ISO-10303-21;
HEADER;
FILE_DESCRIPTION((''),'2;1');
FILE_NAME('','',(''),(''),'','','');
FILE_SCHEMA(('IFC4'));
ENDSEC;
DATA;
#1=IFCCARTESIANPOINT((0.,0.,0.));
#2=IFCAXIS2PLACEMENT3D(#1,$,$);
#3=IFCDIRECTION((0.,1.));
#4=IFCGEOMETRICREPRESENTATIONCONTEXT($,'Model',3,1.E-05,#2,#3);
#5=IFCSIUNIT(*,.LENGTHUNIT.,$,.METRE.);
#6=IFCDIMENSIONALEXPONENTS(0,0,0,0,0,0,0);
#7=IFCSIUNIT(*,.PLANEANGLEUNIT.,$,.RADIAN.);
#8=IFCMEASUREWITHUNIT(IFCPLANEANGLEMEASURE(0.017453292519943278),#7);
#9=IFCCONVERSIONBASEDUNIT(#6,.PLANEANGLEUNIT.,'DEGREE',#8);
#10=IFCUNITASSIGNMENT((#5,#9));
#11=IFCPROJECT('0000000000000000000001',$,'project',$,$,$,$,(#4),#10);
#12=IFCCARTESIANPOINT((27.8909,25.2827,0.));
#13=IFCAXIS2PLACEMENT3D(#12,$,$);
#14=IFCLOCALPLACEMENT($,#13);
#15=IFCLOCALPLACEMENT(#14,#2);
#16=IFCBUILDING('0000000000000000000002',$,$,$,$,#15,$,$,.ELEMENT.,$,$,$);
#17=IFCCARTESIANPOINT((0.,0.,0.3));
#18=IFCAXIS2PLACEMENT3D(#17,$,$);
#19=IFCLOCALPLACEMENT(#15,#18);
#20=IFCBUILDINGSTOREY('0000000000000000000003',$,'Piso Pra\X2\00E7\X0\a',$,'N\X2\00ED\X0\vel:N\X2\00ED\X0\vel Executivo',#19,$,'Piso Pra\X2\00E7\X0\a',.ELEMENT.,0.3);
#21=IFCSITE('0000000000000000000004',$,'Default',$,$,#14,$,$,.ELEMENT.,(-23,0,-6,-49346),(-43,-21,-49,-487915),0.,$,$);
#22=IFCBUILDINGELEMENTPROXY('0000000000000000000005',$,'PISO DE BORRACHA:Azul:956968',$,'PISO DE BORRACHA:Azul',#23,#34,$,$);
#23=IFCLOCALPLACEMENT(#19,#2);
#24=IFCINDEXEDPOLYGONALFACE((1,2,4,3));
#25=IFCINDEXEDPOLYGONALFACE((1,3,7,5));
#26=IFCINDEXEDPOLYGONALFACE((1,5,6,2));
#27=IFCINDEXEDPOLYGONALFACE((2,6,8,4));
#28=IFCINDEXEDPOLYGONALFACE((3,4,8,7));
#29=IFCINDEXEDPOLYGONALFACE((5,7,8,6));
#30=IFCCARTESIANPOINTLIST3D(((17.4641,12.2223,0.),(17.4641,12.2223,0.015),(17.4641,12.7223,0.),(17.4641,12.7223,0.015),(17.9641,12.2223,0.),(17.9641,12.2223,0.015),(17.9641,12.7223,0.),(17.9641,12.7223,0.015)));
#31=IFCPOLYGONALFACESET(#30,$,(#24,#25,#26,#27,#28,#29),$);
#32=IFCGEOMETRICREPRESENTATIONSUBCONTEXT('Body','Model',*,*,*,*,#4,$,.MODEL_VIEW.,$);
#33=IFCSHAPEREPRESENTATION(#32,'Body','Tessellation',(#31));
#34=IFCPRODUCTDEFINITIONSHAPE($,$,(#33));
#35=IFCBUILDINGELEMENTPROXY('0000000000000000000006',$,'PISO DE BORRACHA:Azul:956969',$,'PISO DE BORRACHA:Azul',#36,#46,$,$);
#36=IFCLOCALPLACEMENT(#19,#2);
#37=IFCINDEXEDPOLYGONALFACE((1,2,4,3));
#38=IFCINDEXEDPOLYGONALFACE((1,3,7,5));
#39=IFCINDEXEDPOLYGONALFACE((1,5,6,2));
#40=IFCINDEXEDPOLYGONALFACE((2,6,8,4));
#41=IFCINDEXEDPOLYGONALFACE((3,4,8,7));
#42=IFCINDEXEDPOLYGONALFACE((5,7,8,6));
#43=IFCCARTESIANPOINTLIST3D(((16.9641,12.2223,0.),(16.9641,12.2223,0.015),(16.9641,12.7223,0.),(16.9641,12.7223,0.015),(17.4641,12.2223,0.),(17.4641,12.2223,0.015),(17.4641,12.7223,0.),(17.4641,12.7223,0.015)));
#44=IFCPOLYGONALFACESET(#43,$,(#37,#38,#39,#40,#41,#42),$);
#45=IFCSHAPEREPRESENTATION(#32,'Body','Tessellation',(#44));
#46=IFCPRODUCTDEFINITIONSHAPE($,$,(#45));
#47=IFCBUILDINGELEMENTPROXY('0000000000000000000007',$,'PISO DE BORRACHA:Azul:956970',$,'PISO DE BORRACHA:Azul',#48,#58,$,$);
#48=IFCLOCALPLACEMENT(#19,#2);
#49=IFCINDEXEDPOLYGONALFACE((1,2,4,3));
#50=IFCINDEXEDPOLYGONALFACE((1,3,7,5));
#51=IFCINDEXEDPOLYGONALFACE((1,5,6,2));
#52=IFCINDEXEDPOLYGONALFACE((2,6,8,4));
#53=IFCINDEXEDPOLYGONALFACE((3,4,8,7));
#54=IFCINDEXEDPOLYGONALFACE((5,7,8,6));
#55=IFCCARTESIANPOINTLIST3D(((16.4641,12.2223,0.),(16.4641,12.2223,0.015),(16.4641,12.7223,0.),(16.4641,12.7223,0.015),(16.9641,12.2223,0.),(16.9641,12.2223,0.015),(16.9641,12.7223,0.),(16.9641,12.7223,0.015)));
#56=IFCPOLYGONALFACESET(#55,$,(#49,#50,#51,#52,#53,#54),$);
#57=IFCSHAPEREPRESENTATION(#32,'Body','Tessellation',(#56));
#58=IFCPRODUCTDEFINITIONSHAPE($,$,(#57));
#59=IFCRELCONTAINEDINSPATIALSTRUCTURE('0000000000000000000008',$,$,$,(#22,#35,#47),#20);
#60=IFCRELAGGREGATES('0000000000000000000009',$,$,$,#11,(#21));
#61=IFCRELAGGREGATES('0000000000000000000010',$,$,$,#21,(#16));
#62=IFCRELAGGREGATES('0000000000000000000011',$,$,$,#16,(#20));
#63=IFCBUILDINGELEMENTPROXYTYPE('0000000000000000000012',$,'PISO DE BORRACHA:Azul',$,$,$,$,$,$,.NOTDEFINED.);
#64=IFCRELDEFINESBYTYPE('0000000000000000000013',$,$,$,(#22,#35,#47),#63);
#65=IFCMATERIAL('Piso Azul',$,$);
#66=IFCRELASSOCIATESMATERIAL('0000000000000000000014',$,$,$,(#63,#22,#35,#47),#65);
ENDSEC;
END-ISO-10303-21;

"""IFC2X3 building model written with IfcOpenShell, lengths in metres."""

from ifc_helpers import new_model, entity, si_unit, converted_unit, direction, frame, origin, origin_2d_with_axis, place, context, subcontext, project, spatial, rectangle, extrude, source, transform, mapped, material, type_object, type_shapes, element, save


model = new_model("IFC2X3")

# Units and contexts
model_context = context("Model", 3, precision=1e-05, world=origin(), true_north=direction((0.0, 1.0)))
body_context = subcontext(model_context, "Body", "Model", "MODEL_VIEW")
ifc_project = project(units=[si_unit("LENGTHUNIT", "METRE"), converted_unit("PLANEANGLEUNIT", "DEGREE", entity("IfcPlaneAngleMeasure", 0.017453292519943278), si_unit("PLANEANGLEUNIT", "RADIAN"), dimensions=[0, 0, 0, 0, 0, 0, 0])], contexts=[model_context])

# Site, building, storey
site_placement = place(None, frame((27.8909, 25.2827, 0.0)))
site = spatial("IfcSite", under=ifc_project, at=site_placement, Name="Default", CompositionType="ELEMENT", RefLatitude=(-23, 0, -6, -49346), RefLongitude=(-43, -21, -49, -487915), RefElevation=0.0)
building_placement = place(site_placement, origin())
building = spatial("IfcBuilding", under=site, at=building_placement, CompositionType="ELEMENT")
storey_placement = place(building_placement, frame((0.0, 0.0, 0.3)))
storey = spatial("IfcBuildingStorey", under=building, at=storey_placement, Name="Piso Praça", ObjectType="Nível:Nível Executivo", LongName="Piso Praça", CompositionType="ELEMENT", Elevation=0.3)

# Building element proxies
ifc_material = material(Name="Piso Azul")
building_element_proxy_type = type_object("IfcBuildingElementProxyType", Name="PISO DE BORRACHA:Azul", PredefinedType="NOTDEFINED", material=ifc_material)
shared_shape = source(origin(), body_context, "Body", "SweptSolid", [
    extrude(rectangle(XDim=0.5, YDim=0.5, at=origin_2d_with_axis()), frame((0.25, 0.25, 0.0), z_axis=(0.0, 0.0, 1.0), x_axis=(-1.0, 0.0, 0.0)), (0.0, 0.0, 1.0), 0.015),
])
type_shapes(building_element_proxy_type, [shared_shape])
for number, where, name in (
    (1, (17.4641, 12.2223, 0.0), "PISO DE BORRACHA:Azul:956968"),
    (2, (16.9641, 12.2223, 0.0), "PISO DE BORRACHA:Azul:956969"),
    (3, (16.4641, 12.2223, 0.0), "PISO DE BORRACHA:Azul:956970"),
):
    element("IfcBuildingElementProxy", number, at=place(storey_placement, frame(where)), inside=storey, type_object=building_element_proxy_type, material=ifc_material, Name=name, ObjectType="PISO DE BORRACHA:Azul", context=body_context, shape_type="MappedRepresentation", body=[
        mapped(shared_shape, transform((0.0, 0.0, 0.0), scale=1.0)),
    ])

save(model, "model.ifc")
